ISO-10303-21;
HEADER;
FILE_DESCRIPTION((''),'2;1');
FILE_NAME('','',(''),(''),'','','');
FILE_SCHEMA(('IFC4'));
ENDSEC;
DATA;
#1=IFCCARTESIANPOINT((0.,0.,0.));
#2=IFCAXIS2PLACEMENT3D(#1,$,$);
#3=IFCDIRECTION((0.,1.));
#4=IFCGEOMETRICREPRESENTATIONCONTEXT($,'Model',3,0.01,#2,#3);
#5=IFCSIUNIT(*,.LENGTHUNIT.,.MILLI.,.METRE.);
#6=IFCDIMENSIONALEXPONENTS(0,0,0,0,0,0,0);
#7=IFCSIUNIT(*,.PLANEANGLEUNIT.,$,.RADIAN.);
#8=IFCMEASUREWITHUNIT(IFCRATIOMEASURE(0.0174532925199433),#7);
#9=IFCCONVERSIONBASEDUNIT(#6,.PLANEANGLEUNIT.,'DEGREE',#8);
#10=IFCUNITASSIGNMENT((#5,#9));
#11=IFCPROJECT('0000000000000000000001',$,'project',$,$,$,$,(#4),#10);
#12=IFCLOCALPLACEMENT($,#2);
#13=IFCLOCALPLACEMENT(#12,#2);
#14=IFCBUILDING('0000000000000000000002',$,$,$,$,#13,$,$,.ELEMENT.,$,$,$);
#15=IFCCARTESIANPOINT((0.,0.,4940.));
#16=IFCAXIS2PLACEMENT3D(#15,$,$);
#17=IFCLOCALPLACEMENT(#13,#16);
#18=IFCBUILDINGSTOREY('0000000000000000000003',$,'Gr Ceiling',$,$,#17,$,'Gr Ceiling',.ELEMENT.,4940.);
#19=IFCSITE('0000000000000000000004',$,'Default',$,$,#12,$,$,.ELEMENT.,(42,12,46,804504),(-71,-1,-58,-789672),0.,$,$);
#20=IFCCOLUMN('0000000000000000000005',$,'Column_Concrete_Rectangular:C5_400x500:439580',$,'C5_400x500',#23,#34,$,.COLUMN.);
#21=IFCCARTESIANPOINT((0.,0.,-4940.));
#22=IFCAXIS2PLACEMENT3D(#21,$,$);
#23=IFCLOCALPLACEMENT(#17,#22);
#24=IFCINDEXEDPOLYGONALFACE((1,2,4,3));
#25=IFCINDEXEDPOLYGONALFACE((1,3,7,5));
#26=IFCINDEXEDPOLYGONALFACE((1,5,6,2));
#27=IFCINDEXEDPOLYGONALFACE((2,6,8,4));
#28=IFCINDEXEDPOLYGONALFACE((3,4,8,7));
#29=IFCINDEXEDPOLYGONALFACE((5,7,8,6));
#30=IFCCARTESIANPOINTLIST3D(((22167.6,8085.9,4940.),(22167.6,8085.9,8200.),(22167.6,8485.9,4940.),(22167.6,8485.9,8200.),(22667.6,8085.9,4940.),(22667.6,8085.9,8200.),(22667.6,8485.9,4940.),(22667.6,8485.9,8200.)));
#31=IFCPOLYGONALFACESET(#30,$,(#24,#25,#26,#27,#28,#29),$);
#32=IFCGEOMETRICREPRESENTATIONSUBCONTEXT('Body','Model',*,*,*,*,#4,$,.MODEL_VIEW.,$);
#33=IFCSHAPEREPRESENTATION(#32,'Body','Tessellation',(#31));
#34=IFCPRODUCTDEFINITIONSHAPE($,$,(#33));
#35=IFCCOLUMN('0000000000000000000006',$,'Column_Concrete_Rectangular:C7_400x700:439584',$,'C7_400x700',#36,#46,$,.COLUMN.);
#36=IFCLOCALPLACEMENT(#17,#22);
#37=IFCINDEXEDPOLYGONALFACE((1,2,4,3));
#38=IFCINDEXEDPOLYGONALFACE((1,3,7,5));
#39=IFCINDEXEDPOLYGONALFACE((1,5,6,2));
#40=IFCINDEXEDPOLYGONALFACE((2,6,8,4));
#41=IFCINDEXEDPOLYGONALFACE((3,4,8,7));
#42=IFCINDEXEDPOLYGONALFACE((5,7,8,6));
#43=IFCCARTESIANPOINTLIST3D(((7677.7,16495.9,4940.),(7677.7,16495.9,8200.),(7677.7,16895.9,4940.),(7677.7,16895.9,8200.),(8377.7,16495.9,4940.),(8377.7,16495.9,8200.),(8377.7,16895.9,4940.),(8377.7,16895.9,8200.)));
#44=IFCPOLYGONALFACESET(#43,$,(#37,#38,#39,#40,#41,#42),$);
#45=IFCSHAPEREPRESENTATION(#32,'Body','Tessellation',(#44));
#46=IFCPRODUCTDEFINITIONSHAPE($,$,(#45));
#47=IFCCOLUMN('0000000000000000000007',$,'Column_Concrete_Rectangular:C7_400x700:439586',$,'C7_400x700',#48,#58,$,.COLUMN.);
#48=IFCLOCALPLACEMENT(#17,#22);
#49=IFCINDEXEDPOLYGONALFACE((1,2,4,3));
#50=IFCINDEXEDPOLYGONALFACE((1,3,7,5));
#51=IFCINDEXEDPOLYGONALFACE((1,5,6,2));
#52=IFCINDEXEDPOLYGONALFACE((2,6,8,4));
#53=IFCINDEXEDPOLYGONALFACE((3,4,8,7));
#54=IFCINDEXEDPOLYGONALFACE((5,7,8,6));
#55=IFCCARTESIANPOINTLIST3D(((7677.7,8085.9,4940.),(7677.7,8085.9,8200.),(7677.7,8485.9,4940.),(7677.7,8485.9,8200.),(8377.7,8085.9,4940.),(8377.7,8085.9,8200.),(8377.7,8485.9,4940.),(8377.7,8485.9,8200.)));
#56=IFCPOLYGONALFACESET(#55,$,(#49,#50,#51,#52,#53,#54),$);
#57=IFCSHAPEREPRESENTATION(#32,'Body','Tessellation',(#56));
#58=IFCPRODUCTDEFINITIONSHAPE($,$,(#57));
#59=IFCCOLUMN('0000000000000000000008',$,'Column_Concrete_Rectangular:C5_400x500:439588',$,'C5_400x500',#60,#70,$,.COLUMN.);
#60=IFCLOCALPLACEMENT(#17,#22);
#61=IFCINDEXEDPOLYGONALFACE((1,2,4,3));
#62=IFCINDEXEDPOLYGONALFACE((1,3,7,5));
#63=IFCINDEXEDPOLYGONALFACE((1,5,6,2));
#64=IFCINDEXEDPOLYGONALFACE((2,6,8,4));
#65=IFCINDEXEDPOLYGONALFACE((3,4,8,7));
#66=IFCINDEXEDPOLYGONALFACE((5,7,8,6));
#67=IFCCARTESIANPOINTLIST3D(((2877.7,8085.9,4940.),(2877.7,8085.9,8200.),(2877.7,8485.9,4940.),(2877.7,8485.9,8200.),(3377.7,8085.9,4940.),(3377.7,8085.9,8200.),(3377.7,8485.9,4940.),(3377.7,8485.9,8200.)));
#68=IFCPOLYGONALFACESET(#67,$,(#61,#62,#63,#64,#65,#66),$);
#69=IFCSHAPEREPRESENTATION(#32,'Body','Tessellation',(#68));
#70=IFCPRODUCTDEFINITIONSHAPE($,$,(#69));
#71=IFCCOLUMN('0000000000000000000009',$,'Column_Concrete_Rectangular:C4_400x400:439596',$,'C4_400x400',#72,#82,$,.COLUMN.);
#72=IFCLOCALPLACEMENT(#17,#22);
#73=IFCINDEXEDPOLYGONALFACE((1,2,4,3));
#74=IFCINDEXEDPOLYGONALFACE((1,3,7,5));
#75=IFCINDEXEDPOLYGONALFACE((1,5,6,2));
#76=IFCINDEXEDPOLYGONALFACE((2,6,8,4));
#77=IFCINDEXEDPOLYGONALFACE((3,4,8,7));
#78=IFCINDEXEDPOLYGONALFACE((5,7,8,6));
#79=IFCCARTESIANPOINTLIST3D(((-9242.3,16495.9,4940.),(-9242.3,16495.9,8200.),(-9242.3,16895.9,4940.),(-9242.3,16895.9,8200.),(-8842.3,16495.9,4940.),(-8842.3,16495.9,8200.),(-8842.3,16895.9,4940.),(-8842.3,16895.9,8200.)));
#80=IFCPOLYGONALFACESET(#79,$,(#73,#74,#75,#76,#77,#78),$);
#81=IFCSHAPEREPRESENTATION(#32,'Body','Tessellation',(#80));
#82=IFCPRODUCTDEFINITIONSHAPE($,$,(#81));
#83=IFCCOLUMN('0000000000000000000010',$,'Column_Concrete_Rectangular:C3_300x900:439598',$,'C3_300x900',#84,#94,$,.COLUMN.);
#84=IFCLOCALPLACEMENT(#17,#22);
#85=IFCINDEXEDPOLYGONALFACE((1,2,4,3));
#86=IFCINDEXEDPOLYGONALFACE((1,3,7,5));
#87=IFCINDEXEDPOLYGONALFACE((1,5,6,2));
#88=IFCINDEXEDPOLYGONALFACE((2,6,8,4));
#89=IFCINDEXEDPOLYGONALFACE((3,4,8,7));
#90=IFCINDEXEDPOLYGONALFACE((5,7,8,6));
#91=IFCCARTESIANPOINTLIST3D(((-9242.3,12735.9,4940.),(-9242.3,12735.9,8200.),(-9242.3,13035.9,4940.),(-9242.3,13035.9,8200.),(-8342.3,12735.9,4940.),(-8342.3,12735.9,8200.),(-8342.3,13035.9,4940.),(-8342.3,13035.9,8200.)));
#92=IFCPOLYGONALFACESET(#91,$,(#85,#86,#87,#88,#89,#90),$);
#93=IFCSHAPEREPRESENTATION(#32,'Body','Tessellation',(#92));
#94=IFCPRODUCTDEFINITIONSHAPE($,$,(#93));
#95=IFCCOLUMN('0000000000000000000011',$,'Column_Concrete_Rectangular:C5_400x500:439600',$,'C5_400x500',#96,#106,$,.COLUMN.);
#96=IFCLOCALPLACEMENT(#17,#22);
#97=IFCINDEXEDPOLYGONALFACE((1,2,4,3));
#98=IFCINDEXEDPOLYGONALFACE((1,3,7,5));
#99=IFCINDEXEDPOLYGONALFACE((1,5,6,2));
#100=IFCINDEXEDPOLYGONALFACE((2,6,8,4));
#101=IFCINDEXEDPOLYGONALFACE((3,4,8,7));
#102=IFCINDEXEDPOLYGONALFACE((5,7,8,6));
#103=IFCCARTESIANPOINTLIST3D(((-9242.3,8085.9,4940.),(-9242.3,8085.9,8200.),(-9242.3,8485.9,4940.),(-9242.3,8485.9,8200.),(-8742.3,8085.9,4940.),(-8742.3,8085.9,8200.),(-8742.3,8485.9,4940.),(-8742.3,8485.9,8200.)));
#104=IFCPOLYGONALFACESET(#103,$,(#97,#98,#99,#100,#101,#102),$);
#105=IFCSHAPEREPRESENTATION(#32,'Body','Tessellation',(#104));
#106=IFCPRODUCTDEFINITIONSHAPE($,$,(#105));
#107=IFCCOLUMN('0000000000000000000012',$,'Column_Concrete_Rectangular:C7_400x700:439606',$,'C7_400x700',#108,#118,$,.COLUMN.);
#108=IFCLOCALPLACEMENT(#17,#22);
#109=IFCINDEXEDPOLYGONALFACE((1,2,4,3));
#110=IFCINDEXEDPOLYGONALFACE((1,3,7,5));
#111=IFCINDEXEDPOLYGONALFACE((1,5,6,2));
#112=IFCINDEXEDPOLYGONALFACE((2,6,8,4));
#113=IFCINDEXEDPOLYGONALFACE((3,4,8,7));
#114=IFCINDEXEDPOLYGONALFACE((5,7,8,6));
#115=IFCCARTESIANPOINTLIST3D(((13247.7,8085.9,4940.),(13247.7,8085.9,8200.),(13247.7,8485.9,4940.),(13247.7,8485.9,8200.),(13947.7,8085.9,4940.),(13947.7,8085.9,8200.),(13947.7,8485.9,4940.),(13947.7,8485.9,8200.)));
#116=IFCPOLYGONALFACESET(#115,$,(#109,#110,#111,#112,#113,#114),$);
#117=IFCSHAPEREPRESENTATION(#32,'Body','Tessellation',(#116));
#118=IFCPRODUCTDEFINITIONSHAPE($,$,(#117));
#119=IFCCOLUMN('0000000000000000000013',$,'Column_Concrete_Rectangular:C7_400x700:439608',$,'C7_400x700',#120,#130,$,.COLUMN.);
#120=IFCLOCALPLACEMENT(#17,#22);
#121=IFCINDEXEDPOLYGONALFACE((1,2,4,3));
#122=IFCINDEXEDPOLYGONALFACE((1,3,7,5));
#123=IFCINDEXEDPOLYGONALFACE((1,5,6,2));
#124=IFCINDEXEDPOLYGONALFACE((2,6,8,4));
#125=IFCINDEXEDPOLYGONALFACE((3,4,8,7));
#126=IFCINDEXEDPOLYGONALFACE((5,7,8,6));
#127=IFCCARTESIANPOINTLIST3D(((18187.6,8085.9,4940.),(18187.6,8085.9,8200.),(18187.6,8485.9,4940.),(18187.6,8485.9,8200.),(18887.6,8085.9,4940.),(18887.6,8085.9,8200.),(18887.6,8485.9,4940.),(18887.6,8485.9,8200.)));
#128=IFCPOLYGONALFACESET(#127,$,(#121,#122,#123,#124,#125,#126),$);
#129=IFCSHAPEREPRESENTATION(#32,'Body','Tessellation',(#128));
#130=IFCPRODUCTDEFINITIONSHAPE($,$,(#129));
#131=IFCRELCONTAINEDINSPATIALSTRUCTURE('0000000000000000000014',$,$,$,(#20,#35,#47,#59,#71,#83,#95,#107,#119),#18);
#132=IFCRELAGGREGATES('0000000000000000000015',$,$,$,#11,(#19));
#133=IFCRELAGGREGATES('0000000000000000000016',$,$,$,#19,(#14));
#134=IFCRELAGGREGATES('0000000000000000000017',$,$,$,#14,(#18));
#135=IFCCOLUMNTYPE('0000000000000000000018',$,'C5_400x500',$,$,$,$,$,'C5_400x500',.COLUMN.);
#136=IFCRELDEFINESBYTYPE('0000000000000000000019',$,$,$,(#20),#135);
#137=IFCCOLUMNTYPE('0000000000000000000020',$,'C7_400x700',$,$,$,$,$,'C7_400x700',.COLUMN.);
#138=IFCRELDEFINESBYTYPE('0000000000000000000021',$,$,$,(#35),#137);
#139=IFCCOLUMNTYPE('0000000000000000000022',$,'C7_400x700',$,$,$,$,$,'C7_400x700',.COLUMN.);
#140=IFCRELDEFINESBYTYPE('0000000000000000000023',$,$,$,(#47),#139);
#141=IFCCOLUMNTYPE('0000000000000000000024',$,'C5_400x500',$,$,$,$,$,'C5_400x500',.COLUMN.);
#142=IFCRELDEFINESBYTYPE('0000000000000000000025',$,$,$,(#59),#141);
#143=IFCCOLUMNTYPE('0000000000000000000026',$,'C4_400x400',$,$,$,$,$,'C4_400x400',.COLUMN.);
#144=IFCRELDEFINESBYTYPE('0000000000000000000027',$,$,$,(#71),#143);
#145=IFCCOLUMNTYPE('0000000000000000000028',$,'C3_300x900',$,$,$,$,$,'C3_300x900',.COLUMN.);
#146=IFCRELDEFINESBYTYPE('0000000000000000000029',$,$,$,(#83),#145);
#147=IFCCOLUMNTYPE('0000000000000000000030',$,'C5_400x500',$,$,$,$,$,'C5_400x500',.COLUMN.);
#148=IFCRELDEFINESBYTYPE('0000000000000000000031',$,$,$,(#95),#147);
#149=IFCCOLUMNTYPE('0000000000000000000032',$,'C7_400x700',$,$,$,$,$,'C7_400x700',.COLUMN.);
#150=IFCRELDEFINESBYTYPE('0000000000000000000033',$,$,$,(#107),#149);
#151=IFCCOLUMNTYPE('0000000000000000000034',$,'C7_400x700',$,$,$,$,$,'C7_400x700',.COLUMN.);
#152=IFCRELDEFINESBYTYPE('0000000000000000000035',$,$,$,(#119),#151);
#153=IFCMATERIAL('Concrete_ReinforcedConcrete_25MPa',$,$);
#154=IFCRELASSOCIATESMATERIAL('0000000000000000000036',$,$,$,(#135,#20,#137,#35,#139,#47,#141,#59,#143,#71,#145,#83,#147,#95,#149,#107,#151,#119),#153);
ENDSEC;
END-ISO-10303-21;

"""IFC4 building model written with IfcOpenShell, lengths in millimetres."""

from ifc_helpers import new_model, entity, si_unit, converted_unit, direction, frame, frame_2d, origin, origin_2d_with_axis, place, context, subcontext, project, spatial, rectangle, extrude, source, transform, mapped, material, type_object, type_shapes, element, save


model = new_model("IFC4")

# Units and contexts
model_context = context("Model", 3, precision=0.01, world=origin(), true_north=direction((0.0, 1.0)))
body_context = subcontext(model_context, "Body", "Model", "MODEL_VIEW")
ifc_project = project(units=[si_unit("LENGTHUNIT", "METRE", prefix="MILLI"), converted_unit("PLANEANGLEUNIT", "DEGREE", entity("IfcRatioMeasure", 0.0174532925199433), si_unit("PLANEANGLEUNIT", "RADIAN"), dimensions=[0, 0, 0, 0, 0, 0, 0])], contexts=[model_context])

# Site, building, storey
site_placement = place(None, origin())
site = spatial("IfcSite", under=ifc_project, at=site_placement, Name="Default", CompositionType="ELEMENT", RefLatitude=(42, 12, 46, 804504), RefLongitude=(-71, -1, -58, -789672), RefElevation=0.0)
building_placement = place(site_placement, origin())
building = spatial("IfcBuilding", under=site, at=building_placement, CompositionType="ELEMENT")
storey_placement = place(building_placement, frame((0.0, 0.0, 4940.0)))
storey = spatial("IfcBuildingStorey", under=building, at=storey_placement, Name="Gr Ceiling", LongName="Gr Ceiling", CompositionType="ELEMENT", Elevation=4940.0)

# Columns
ifc_material = material(Name="Concrete_ReinforcedConcrete_25MPa")
column_type_1 = type_object("IfcColumnType", Name="C5_400x500", ElementType="C5_400x500", PredefinedType="COLUMN", material=ifc_material)
shared_shape_1 = source(origin(), body_context, "Body", "SweptSolid", [
    extrude(rectangle(XDim=400.0, YDim=500.0, at=frame_2d((0.0, 0.0), x_axis=(1.0, 0.0))), frame((22417.6, 8285.9, 4940.0), z_axis=(0.0, 0.0, 1.0), x_axis=(0.0, -1.0, 0.0)), (0.0, 0.0, 1.0), 3260.0),
])
type_shapes(column_type_1, [shared_shape_1])
column_1_placement = place(storey_placement, frame((0.0, 0.0, -4940.0)))
element("IfcColumn", 1, at=column_1_placement, inside=storey, type_object=column_type_1, material=ifc_material, Name="Column_Concrete_Rectangular:C5_400x500:439580", ObjectType="C5_400x500", PredefinedType="COLUMN", context=body_context, shape_type="MappedRepresentation", body=[
    mapped(shared_shape_1, transform((0.0, 0.0, 0.0), scale=1.0)),
])
column_type_2 = type_object("IfcColumnType", Name="C7_400x700", ElementType="C7_400x700", PredefinedType="COLUMN", material=ifc_material)
shared_shape_2 = source(origin(), body_context, "Body", "SweptSolid", [
    extrude(rectangle(XDim=400.0, YDim=700.0, at=frame_2d((0.0, 0.0), x_axis=(1.0, 0.0))), frame((8027.7, 16695.9, 4940.0), z_axis=(0.0, 0.0, 1.0), x_axis=(0.0, -1.0, 0.0)), (0.0, 0.0, 1.0), 3260.0),
])
type_shapes(column_type_2, [shared_shape_2])
column_2_placement = place(storey_placement, frame((0.0, 0.0, -4940.0)))
element("IfcColumn", 2, at=column_2_placement, inside=storey, type_object=column_type_2, material=ifc_material, Name="Column_Concrete_Rectangular:C7_400x700:439584", ObjectType="C7_400x700", PredefinedType="COLUMN", context=body_context, shape_type="MappedRepresentation", body=[
    mapped(shared_shape_2, transform((0.0, 0.0, 0.0), scale=1.0)),
])
column_type_3 = type_object("IfcColumnType", Name="C7_400x700", ElementType="C7_400x700", PredefinedType="COLUMN", material=ifc_material)
shared_shape_3 = source(origin(), body_context, "Body", "SweptSolid", [
    extrude(rectangle(XDim=400.0, YDim=700.0, at=origin_2d_with_axis()), frame((8027.7, 8285.9, 4940.0), z_axis=(0.0, 0.0, 1.0), x_axis=(0.0, -1.0, 0.0)), (0.0, 0.0, 1.0), 3260.0),
])
type_shapes(column_type_3, [shared_shape_3])
column_3_placement = place(storey_placement, frame((0.0, 0.0, -4940.0)))
element("IfcColumn", 3, at=column_3_placement, inside=storey, type_object=column_type_3, material=ifc_material, Name="Column_Concrete_Rectangular:C7_400x700:439586", ObjectType="C7_400x700", PredefinedType="COLUMN", context=body_context, shape_type="MappedRepresentation", body=[
    mapped(shared_shape_3, transform((0.0, 0.0, 0.0), scale=1.0)),
])
column_type_4 = type_object("IfcColumnType", Name="C5_400x500", ElementType="C5_400x500", PredefinedType="COLUMN", material=ifc_material)
shared_shape_4 = source(origin(), body_context, "Body", "SweptSolid", [
    extrude(rectangle(XDim=400.0, YDim=500.0, at=origin_2d_with_axis()), frame((3127.7, 8285.9, 4940.0), z_axis=(0.0, 0.0, 1.0), x_axis=(0.0, -1.0, 0.0)), (0.0, 0.0, 1.0), 3260.0),
])
type_shapes(column_type_4, [shared_shape_4])
column_4_placement = place(storey_placement, frame((0.0, 0.0, -4940.0)))
element("IfcColumn", 4, at=column_4_placement, inside=storey, type_object=column_type_4, material=ifc_material, Name="Column_Concrete_Rectangular:C5_400x500:439588", ObjectType="C5_400x500", PredefinedType="COLUMN", context=body_context, shape_type="MappedRepresentation", body=[
    mapped(shared_shape_4, transform((0.0, 0.0, 0.0), scale=1.0)),
])
column_type_5 = type_object("IfcColumnType", Name="C4_400x400", ElementType="C4_400x400", PredefinedType="COLUMN", material=ifc_material)
shared_shape_5 = source(origin(), body_context, "Body", "SweptSolid", [
    extrude(rectangle(XDim=400.0, YDim=400.0, at=origin_2d_with_axis()), frame((-9042.3, 16695.9, 4940.0), z_axis=(0.0, 0.0, 1.0), x_axis=(0.0, -1.0, 0.0)), (0.0, 0.0, 1.0), 3260.0),
])
type_shapes(column_type_5, [shared_shape_5])
column_5_placement = place(storey_placement, frame((0.0, 0.0, -4940.0)))
element("IfcColumn", 5, at=column_5_placement, inside=storey, type_object=column_type_5, material=ifc_material, Name="Column_Concrete_Rectangular:C4_400x400:439596", ObjectType="C4_400x400", PredefinedType="COLUMN", context=body_context, shape_type="MappedRepresentation", body=[
    mapped(shared_shape_5, transform((0.0, 0.0, 0.0), scale=1.0)),
])
column_type_6 = type_object("IfcColumnType", Name="C3_300x900", ElementType="C3_300x900", PredefinedType="COLUMN", material=ifc_material)
shared_shape_6 = source(origin(), body_context, "Body", "SweptSolid", [
    extrude(rectangle(XDim=300.0, YDim=900.0, at=frame_2d((0.0, 0.0), x_axis=(1.0, 0.0))), frame((-8792.3, 12885.9, 4940.0), z_axis=(0.0, 0.0, 1.0), x_axis=(0.0, -1.0, 0.0)), (0.0, 0.0, 1.0), 3260.0),
])
type_shapes(column_type_6, [shared_shape_6])
column_6_placement = place(storey_placement, frame((0.0, 0.0, -4940.0)))
element("IfcColumn", 6, at=column_6_placement, inside=storey, type_object=column_type_6, material=ifc_material, Name="Column_Concrete_Rectangular:C3_300x900:439598", ObjectType="C3_300x900", PredefinedType="COLUMN", context=body_context, shape_type="MappedRepresentation", body=[
    mapped(shared_shape_6, transform((0.0, 0.0, 0.0), scale=1.0)),
])
column_type_7 = type_object("IfcColumnType", Name="C5_400x500", ElementType="C5_400x500", PredefinedType="COLUMN", material=ifc_material)
shared_shape_7 = source(origin(), body_context, "Body", "SweptSolid", [
    extrude(rectangle(XDim=400.0, YDim=500.0, at=frame_2d((0.0, 0.0), x_axis=(1.0, 0.0))), frame((-8992.3, 8285.9, 4940.0), z_axis=(0.0, 0.0, 1.0), x_axis=(0.0, -1.0, 0.0)), (0.0, 0.0, 1.0), 3260.0),
])
type_shapes(column_type_7, [shared_shape_7])
column_7_placement = place(storey_placement, frame((0.0, 0.0, -4940.0)))
element("IfcColumn", 7, at=column_7_placement, inside=storey, type_object=column_type_7, material=ifc_material, Name="Column_Concrete_Rectangular:C5_400x500:439600", ObjectType="C5_400x500", PredefinedType="COLUMN", context=body_context, shape_type="MappedRepresentation", body=[
    mapped(shared_shape_7, transform((0.0, 0.0, 0.0), scale=1.0)),
])
column_type_8 = type_object("IfcColumnType", Name="C7_400x700", ElementType="C7_400x700", PredefinedType="COLUMN", material=ifc_material)
shared_shape_8 = source(origin(), body_context, "Body", "SweptSolid", [
    extrude(rectangle(XDim=400.0, YDim=700.0, at=frame_2d((0.0, 0.0), x_axis=(1.0, 0.0))), frame((13597.7, 8285.9, 4940.0), z_axis=(0.0, 0.0, 1.0), x_axis=(0.0, -1.0, 0.0)), (0.0, 0.0, 1.0), 3260.0),
])
type_shapes(column_type_8, [shared_shape_8])
column_8_placement = place(storey_placement, frame((0.0, 0.0, -4940.0)))
element("IfcColumn", 8, at=column_8_placement, inside=storey, type_object=column_type_8, material=ifc_material, Name="Column_Concrete_Rectangular:C7_400x700:439606", ObjectType="C7_400x700", PredefinedType="COLUMN", context=body_context, shape_type="MappedRepresentation", body=[
    mapped(shared_shape_8, transform((0.0, 0.0, 0.0), scale=1.0)),
])
column_type_9 = type_object("IfcColumnType", Name="C7_400x700", ElementType="C7_400x700", PredefinedType="COLUMN", material=ifc_material)
shared_shape_9 = source(origin(), body_context, "Body", "SweptSolid", [
    extrude(rectangle(XDim=400.0, YDim=700.0, at=origin_2d_with_axis()), frame((18537.6, 8285.9, 4940.0), z_axis=(0.0, 0.0, 1.0), x_axis=(0.0, -1.0, 0.0)), (0.0, 0.0, 1.0), 3260.0),
])
type_shapes(column_type_9, [shared_shape_9])
column_9_placement = place(storey_placement, frame((0.0, 0.0, -4940.0)))
element("IfcColumn", 9, at=column_9_placement, inside=storey, type_object=column_type_9, material=ifc_material, Name="Column_Concrete_Rectangular:C7_400x700:439608", ObjectType="C7_400x700", PredefinedType="COLUMN", context=body_context, shape_type="MappedRepresentation", body=[
    mapped(shared_shape_9, transform((0.0, 0.0, 0.0), scale=1.0)),
])

save(model, "model.ifc")
